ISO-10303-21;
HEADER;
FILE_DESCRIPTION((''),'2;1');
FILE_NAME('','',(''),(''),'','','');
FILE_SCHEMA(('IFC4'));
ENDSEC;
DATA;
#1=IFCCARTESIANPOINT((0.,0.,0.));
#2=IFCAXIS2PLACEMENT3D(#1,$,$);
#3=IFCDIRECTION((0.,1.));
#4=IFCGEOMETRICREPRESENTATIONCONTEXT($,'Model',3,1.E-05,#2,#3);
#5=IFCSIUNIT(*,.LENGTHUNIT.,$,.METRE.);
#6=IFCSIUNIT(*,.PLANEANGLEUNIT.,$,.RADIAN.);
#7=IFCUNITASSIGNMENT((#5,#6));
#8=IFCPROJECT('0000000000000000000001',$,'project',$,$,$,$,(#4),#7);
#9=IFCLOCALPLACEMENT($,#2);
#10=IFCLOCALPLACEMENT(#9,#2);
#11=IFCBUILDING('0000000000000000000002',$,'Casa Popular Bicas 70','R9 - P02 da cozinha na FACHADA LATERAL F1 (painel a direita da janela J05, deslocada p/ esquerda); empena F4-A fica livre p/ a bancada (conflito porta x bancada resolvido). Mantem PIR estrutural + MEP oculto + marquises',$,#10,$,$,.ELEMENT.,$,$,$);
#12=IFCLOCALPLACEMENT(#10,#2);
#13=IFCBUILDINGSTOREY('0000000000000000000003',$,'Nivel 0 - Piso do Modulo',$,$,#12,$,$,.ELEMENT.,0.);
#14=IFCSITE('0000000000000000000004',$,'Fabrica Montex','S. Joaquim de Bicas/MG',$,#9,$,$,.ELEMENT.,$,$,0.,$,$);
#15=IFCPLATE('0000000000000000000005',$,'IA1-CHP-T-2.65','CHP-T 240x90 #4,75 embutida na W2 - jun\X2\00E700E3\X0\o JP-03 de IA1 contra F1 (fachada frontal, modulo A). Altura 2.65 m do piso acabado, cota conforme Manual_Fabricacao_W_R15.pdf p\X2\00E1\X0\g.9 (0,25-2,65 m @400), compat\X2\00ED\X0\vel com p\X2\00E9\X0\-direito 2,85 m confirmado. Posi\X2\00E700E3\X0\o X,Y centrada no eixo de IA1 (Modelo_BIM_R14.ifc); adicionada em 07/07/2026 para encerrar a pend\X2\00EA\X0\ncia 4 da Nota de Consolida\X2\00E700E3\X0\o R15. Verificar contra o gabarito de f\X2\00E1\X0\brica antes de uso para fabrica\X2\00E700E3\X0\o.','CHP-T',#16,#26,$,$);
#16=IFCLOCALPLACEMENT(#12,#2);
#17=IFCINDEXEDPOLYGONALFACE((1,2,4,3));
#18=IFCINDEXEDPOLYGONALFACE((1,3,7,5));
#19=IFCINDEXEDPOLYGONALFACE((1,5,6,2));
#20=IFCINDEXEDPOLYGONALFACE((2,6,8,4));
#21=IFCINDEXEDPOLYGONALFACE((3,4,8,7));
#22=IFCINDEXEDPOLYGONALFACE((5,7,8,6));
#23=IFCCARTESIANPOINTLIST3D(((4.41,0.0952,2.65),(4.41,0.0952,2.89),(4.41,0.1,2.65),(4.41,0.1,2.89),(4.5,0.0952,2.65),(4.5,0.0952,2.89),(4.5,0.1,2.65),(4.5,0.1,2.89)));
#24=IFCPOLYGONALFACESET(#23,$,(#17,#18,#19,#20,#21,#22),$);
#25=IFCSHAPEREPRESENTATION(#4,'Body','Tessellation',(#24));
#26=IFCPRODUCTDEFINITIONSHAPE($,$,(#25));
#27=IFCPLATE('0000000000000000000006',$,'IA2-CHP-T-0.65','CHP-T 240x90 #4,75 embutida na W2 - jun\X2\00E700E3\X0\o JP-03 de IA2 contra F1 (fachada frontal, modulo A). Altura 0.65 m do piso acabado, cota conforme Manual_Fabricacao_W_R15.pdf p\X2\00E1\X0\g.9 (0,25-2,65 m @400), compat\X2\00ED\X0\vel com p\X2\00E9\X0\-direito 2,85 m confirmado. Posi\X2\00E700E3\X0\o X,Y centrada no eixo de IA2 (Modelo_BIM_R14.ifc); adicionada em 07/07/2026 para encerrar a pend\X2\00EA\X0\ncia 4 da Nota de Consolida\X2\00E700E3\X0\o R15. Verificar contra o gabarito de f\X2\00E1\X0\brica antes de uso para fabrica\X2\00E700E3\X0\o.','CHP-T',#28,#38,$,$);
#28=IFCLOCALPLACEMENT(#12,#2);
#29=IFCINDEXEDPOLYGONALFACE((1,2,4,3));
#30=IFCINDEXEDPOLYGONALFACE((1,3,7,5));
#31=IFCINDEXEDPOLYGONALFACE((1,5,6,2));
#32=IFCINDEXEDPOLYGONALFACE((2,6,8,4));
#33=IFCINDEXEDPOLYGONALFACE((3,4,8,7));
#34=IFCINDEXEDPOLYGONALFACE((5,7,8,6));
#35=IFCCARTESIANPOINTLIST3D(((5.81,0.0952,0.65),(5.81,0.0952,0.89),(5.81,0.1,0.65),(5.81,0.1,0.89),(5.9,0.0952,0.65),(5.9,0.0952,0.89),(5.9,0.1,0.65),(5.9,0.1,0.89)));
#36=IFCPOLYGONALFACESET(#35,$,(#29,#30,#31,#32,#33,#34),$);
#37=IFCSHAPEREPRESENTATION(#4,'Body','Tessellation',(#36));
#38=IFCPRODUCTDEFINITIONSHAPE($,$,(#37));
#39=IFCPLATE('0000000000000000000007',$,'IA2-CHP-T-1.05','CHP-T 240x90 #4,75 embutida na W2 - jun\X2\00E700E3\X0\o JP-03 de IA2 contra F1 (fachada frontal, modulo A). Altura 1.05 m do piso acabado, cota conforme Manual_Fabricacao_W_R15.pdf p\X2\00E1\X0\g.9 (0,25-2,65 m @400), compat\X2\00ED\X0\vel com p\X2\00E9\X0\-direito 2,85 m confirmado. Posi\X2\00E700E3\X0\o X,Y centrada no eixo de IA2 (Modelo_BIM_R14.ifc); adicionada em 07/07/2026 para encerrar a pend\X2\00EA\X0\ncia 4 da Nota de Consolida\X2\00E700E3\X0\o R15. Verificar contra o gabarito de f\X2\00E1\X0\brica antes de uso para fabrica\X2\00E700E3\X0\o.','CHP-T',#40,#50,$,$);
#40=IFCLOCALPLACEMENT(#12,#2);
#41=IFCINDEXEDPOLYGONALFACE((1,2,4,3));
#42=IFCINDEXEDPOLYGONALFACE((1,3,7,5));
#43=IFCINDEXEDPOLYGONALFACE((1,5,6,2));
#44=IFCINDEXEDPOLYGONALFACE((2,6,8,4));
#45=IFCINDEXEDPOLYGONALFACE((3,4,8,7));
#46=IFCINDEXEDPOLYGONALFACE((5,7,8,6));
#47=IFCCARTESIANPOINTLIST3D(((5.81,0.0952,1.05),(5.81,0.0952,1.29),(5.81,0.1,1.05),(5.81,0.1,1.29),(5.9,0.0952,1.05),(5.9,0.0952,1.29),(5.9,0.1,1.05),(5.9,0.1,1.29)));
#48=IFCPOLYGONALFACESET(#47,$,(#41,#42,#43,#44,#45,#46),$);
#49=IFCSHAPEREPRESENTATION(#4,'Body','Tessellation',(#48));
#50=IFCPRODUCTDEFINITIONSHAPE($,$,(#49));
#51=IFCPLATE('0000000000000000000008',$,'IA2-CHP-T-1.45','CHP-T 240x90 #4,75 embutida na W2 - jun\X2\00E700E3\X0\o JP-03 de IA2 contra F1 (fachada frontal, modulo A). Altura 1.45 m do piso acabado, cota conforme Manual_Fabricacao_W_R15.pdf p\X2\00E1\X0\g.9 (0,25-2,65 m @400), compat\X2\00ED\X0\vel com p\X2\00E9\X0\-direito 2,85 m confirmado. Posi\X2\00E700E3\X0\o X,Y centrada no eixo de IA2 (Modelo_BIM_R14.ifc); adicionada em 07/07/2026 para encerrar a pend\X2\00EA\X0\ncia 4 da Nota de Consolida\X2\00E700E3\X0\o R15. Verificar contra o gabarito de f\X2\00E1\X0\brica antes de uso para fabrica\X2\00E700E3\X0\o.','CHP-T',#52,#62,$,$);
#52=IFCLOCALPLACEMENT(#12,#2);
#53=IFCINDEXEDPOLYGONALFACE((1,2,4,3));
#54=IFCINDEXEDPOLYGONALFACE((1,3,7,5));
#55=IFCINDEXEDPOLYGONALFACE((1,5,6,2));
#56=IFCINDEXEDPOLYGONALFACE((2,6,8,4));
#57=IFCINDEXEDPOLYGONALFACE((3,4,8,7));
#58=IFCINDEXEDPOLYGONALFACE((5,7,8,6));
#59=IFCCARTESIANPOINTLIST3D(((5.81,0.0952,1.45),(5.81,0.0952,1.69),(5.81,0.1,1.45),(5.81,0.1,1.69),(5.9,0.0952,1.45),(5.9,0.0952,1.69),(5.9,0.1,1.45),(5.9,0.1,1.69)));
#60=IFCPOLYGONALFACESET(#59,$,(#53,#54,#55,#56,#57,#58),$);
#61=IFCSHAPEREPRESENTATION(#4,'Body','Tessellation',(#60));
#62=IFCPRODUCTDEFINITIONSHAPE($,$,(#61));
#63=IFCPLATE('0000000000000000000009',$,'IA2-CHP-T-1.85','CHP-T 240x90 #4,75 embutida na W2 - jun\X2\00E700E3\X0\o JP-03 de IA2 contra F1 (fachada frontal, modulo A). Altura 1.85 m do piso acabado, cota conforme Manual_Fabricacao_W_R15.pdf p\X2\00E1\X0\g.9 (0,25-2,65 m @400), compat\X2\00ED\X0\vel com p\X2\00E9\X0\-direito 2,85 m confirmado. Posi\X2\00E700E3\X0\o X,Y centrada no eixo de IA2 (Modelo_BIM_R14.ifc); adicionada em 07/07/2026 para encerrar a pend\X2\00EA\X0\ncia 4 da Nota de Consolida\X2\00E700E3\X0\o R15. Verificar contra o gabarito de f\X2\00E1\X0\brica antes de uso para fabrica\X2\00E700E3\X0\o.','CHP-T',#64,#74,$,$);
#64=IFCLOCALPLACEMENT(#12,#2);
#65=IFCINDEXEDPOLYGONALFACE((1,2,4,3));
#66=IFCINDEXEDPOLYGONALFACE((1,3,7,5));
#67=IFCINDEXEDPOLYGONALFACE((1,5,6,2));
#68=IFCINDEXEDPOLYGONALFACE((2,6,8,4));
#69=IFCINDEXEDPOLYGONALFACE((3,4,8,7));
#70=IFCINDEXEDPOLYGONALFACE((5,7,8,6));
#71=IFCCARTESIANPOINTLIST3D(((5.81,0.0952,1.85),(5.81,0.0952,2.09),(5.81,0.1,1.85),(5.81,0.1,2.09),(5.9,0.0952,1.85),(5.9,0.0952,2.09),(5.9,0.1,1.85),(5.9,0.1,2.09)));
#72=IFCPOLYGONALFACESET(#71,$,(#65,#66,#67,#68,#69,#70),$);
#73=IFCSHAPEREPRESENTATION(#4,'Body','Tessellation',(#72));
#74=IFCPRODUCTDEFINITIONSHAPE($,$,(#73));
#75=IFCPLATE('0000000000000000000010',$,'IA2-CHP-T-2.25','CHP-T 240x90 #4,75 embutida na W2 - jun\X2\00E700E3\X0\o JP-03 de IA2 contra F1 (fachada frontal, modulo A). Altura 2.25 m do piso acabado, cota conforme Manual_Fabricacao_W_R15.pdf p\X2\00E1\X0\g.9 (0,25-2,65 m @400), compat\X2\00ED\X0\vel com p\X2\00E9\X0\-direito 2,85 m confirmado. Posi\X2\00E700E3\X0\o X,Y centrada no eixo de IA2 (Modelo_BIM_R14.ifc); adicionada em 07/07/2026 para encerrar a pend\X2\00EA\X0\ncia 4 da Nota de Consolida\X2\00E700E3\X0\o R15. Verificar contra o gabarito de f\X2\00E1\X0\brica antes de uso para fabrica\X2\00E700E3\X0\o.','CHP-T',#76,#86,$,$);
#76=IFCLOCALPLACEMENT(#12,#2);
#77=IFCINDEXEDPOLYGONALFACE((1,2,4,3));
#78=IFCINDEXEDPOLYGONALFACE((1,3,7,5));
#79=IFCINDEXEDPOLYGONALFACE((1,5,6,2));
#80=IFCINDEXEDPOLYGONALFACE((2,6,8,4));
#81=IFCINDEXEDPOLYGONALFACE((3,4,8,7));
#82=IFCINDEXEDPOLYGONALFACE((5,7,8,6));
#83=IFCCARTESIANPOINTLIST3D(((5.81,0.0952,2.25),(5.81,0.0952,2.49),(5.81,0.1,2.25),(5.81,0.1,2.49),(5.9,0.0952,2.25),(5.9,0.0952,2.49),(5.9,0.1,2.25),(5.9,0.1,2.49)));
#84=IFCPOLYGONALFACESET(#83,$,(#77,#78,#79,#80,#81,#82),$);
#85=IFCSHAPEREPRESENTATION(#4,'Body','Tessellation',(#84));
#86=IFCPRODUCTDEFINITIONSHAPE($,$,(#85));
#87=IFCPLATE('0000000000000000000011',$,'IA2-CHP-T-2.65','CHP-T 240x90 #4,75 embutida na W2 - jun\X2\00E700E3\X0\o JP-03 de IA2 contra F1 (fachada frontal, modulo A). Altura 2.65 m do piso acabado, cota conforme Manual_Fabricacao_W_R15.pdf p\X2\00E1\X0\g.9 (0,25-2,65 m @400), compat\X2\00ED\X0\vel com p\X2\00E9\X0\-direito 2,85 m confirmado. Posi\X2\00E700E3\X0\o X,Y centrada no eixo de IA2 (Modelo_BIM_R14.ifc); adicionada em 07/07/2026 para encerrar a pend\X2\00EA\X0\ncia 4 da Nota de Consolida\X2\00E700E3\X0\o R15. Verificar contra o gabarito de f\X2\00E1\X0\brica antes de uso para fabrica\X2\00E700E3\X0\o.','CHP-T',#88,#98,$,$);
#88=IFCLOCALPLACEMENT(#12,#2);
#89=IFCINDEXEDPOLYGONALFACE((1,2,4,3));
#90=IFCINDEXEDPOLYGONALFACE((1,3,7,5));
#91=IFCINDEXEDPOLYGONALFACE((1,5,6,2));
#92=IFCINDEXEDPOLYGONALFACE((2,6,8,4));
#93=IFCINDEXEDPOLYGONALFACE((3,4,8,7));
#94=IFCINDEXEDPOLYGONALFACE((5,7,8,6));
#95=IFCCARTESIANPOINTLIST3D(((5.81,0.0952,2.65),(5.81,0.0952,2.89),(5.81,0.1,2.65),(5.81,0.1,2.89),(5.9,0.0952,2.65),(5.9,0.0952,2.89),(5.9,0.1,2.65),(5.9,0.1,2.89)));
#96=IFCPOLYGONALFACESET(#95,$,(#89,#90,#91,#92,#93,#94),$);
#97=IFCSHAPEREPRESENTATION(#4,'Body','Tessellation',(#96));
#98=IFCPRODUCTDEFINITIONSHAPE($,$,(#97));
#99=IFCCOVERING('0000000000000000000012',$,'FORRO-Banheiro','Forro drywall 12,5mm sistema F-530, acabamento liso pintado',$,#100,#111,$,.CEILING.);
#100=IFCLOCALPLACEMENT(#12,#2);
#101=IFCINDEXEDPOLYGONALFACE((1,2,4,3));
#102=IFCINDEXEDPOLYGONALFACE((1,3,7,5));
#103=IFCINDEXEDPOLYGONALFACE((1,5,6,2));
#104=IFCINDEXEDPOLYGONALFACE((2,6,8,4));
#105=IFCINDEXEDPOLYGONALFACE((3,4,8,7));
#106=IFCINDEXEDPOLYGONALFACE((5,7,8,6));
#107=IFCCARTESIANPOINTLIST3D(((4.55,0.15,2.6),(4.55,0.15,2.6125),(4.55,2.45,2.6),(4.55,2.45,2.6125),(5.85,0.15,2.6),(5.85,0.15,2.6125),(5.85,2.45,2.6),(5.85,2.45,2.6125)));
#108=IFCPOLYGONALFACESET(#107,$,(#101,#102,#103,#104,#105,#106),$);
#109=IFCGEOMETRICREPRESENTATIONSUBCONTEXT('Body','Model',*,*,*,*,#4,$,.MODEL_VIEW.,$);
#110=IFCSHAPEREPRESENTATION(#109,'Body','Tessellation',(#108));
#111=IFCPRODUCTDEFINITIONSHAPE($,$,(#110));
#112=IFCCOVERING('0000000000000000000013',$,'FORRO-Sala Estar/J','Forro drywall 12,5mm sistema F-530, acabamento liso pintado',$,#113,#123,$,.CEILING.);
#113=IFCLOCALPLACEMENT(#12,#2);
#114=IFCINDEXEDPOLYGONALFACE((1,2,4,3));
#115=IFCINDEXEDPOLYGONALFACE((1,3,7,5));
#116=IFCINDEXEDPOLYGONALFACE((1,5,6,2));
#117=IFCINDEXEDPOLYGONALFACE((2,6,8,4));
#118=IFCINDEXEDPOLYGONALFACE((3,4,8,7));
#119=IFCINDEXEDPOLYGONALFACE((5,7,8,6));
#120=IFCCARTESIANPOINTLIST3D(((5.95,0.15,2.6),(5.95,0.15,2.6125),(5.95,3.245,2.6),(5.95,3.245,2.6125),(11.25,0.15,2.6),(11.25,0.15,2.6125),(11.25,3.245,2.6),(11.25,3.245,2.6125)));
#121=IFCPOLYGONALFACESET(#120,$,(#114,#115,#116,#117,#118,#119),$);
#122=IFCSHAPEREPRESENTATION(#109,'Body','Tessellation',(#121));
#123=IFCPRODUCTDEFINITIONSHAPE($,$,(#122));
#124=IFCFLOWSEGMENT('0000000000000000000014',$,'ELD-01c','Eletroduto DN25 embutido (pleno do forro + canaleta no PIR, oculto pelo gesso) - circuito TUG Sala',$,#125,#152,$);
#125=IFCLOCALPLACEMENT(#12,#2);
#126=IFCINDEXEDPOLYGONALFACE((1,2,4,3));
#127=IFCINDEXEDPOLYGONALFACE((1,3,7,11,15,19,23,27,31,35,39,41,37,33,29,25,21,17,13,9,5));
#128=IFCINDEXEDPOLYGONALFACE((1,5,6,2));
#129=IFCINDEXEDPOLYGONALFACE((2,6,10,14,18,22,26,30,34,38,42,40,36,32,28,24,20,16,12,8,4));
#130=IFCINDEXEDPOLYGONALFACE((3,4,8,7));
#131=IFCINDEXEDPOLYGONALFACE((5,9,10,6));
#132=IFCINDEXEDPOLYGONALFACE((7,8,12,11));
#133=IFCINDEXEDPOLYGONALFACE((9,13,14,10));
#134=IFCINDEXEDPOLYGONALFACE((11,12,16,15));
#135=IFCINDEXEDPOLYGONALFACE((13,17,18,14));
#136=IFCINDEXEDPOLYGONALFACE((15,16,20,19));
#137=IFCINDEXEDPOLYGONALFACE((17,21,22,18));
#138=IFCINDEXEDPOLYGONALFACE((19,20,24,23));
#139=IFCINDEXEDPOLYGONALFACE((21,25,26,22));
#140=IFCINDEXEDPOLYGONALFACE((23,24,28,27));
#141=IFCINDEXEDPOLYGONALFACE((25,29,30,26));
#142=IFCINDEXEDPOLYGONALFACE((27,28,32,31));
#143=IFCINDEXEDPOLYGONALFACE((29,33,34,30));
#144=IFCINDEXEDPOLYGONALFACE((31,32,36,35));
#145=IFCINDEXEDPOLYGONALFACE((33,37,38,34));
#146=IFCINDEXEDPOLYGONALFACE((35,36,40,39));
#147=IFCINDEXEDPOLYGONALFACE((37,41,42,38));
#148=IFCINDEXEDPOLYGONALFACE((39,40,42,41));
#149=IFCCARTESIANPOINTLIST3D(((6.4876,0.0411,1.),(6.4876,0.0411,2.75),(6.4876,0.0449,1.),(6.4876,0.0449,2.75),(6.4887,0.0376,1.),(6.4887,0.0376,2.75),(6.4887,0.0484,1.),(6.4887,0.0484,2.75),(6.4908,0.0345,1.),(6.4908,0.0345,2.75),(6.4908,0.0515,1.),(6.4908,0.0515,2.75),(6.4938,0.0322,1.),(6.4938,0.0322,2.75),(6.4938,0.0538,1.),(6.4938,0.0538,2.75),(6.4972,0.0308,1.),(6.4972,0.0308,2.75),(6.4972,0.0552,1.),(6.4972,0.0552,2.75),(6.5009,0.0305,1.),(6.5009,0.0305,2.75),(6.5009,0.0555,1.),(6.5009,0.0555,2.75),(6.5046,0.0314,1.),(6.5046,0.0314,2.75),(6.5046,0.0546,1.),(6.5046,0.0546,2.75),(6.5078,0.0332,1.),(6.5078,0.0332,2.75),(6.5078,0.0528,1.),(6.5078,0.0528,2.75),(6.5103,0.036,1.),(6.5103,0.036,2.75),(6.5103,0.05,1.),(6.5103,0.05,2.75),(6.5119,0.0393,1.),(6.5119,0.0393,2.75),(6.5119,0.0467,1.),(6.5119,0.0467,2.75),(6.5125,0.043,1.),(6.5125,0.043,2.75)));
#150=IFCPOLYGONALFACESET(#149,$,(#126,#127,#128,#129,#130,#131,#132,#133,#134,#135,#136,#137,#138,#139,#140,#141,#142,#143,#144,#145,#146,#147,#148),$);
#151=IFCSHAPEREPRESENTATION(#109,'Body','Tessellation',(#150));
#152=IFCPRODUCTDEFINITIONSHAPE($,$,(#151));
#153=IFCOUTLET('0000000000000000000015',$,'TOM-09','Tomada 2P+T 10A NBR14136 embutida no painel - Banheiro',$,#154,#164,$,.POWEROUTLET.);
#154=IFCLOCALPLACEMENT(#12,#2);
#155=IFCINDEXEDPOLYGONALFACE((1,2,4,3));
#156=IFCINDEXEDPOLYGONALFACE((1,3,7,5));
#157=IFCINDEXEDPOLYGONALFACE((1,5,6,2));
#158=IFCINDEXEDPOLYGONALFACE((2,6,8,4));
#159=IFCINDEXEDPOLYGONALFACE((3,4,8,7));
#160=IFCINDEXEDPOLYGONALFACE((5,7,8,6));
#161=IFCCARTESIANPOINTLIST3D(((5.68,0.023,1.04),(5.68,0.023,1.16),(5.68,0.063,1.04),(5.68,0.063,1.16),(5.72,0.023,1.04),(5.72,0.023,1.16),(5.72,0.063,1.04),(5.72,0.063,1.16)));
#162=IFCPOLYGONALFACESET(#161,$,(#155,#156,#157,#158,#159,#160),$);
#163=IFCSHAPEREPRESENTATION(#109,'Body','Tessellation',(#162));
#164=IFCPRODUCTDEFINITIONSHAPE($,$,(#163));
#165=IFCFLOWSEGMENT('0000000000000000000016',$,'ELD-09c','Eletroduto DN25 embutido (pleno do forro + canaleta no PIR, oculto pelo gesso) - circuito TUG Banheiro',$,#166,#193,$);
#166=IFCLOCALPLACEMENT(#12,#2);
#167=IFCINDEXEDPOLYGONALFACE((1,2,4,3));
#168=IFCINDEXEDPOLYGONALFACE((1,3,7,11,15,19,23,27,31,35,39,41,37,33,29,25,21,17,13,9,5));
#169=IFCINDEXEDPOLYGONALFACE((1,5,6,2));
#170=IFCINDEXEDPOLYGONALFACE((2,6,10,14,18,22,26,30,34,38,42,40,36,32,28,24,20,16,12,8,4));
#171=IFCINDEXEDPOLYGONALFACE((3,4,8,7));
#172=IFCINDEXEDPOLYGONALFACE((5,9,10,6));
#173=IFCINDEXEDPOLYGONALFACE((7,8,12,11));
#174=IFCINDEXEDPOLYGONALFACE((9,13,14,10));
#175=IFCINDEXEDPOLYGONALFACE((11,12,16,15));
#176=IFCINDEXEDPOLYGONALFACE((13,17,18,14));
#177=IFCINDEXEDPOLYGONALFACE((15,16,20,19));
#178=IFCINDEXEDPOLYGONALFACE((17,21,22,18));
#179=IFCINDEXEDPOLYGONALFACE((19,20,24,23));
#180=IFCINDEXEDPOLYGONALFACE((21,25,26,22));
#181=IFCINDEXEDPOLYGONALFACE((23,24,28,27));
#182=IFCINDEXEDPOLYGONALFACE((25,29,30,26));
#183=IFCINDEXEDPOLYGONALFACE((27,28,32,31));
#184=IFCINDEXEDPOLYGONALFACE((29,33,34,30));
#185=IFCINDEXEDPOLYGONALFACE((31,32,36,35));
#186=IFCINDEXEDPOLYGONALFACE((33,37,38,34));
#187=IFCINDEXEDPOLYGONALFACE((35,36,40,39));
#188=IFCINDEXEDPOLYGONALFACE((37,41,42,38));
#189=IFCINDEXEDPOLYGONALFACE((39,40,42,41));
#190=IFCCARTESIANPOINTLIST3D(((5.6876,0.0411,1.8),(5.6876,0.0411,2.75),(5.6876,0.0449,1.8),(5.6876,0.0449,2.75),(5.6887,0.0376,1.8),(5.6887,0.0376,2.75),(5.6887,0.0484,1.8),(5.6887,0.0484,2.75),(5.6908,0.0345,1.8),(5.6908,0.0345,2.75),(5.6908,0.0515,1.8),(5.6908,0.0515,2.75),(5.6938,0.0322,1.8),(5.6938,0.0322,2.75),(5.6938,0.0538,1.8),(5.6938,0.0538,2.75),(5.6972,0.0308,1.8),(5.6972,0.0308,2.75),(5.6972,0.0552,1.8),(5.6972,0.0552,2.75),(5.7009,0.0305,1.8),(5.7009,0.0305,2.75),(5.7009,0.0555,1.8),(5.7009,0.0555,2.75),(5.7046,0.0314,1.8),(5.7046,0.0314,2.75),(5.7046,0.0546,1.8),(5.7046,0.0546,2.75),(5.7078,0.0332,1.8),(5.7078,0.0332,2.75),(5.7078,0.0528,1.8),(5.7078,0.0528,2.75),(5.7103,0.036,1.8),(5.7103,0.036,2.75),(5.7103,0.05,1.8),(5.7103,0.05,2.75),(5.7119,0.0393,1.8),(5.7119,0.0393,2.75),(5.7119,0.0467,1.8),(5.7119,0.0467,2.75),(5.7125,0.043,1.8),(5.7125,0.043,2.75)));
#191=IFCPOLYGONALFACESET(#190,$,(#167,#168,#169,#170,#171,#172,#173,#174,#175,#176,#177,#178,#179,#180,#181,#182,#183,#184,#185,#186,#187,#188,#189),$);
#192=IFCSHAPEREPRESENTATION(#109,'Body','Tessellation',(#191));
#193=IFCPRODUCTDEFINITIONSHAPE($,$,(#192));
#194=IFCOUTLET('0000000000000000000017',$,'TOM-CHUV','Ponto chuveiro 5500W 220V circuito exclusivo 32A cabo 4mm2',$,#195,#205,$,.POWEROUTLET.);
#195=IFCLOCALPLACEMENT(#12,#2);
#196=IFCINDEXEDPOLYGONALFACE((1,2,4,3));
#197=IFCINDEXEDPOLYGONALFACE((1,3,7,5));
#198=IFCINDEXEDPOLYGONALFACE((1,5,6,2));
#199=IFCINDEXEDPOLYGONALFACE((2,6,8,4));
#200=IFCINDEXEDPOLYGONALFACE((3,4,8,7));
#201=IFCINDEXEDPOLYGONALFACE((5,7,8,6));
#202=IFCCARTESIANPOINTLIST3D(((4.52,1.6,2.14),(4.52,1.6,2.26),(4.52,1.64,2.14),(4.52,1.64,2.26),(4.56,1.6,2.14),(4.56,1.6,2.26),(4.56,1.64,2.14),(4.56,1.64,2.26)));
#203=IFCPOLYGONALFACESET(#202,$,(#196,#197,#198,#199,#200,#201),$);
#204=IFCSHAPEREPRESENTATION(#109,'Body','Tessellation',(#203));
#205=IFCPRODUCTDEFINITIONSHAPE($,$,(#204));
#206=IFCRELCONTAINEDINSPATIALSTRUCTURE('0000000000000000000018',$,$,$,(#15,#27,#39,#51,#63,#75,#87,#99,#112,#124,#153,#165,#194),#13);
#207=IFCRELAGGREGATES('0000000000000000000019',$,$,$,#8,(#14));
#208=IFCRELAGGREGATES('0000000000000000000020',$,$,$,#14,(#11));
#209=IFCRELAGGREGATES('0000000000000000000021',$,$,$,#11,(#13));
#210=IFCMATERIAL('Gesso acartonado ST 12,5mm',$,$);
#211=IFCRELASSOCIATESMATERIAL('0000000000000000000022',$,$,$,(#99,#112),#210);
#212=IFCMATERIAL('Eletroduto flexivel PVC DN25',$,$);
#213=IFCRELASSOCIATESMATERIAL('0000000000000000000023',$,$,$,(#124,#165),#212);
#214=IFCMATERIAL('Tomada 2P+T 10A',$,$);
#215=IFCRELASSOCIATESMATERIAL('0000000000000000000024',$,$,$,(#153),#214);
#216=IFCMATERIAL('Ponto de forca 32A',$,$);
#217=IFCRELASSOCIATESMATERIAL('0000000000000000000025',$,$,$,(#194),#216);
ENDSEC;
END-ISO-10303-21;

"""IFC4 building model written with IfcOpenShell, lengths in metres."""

from ifc_helpers import new_model, si_unit, direction, frame, frame_2d, origin, origin_with_axes, origin_2d, place, context, subcontext, project, spatial, rectangle, circle, extrude, material, element, save


model = new_model("IFC4")

# Units and contexts
model_context = context("Model", 3, precision=1e-05, world=origin(), true_north=direction((0.0, 1.0)))
body_context = subcontext(model_context, "Body", "Model", "MODEL_VIEW")
ifc_project = project(units=[si_unit("LENGTHUNIT", "METRE"), si_unit("PLANEANGLEUNIT", "RADIAN")], contexts=[model_context])

# Site, building, storey
site_placement = place(None, origin())
site = spatial("IfcSite", under=ifc_project, at=site_placement, Name="Fabrica Montex", Description="S. Joaquim de Bicas/MG", CompositionType="ELEMENT", RefElevation=0.0)
building_placement = place(site_placement, origin())
building = spatial("IfcBuilding", under=site, at=building_placement, Name="Casa Popular Bicas 70", Description="R9 - P02 da cozinha na FACHADA LATERAL F1 (painel a direita da janela J05, deslocada p/ esquerda); empena F4-A fica livre p/ a bancada (conflito porta x bancada resolvido). Mantem PIR estrutural + MEP oculto + marquises", CompositionType="ELEMENT")
storey_placement = place(building_placement, origin())
storey = spatial("IfcBuildingStorey", under=building, at=storey_placement, Name="Nivel 0 - Piso do Modulo", CompositionType="ELEMENT", Elevation=0.0)

# Plates
for number, where, z_axis, x_axis, name, description in (
    (1, (4.455, 0.0976, 2.65), (0.0, 0.0, 1.0), (1.0, 0.0, 0.0), "IA1-CHP-T-2.65", "CHP-T 240x90 #4,75 embutida na W2 - junção JP-03 de IA1 contra F1 (fachada frontal, modulo A). Altura 2.65 m do piso acabado, cota conforme Manual_Fabricacao_W_R15.pdf pág.9 (0,25-2,65 m @400), compatível com pé-direito 2,85 m confirmado. Posição X,Y centrada no eixo de IA1 (Modelo_BIM_R14.ifc); adicionada em 07/07/2026 para encerrar a pendência 4 da Nota de Consolidação R15. Verificar contra o gabarito de fábrica antes de uso para fabricação."),
    (2, (5.855, 0.0976, 0.65), (0.0, 0.0, 1.0), (1.0, 0.0, 0.0), "IA2-CHP-T-0.65", "CHP-T 240x90 #4,75 embutida na W2 - junção JP-03 de IA2 contra F1 (fachada frontal, modulo A). Altura 0.65 m do piso acabado, cota conforme Manual_Fabricacao_W_R15.pdf pág.9 (0,25-2,65 m @400), compatível com pé-direito 2,85 m confirmado. Posição X,Y centrada no eixo de IA2 (Modelo_BIM_R14.ifc); adicionada em 07/07/2026 para encerrar a pendência 4 da Nota de Consolidação R15. Verificar contra o gabarito de fábrica antes de uso para fabricação."),
    (3, (5.855, 0.0976, 1.05), (0.0, 0.0, 1.0), (1.0, 0.0, 0.0), "IA2-CHP-T-1.05", "CHP-T 240x90 #4,75 embutida na W2 - junção JP-03 de IA2 contra F1 (fachada frontal, modulo A). Altura 1.05 m do piso acabado, cota conforme Manual_Fabricacao_W_R15.pdf pág.9 (0,25-2,65 m @400), compatível com pé-direito 2,85 m confirmado. Posição X,Y centrada no eixo de IA2 (Modelo_BIM_R14.ifc); adicionada em 07/07/2026 para encerrar a pendência 4 da Nota de Consolidação R15. Verificar contra o gabarito de fábrica antes de uso para fabricação."),
    (4, (5.855, 0.0976, 1.45), (0.0, 0.0, 1.0), (1.0, 0.0, 0.0), "IA2-CHP-T-1.45", "CHP-T 240x90 #4,75 embutida na W2 - junção JP-03 de IA2 contra F1 (fachada frontal, modulo A). Altura 1.45 m do piso acabado, cota conforme Manual_Fabricacao_W_R15.pdf pág.9 (0,25-2,65 m @400), compatível com pé-direito 2,85 m confirmado. Posição X,Y centrada no eixo de IA2 (Modelo_BIM_R14.ifc); adicionada em 07/07/2026 para encerrar a pendência 4 da Nota de Consolidação R15. Verificar contra o gabarito de fábrica antes de uso para fabricação."),
    (5, (5.855, 0.0976, 1.85), (0.0, 0.0, 1.0), (1.0, 0.0, 0.0), "IA2-CHP-T-1.85", "CHP-T 240x90 #4,75 embutida na W2 - junção JP-03 de IA2 contra F1 (fachada frontal, modulo A). Altura 1.85 m do piso acabado, cota conforme Manual_Fabricacao_W_R15.pdf pág.9 (0,25-2,65 m @400), compatível com pé-direito 2,85 m confirmado. Posição X,Y centrada no eixo de IA2 (Modelo_BIM_R14.ifc); adicionada em 07/07/2026 para encerrar a pendência 4 da Nota de Consolidação R15. Verificar contra o gabarito de fábrica antes de uso para fabricação."),
    (6, (5.855, 0.0976, 2.25), (0.0, 0.0, 1.0), (1.0, 0.0, 0.0), "IA2-CHP-T-2.25", "CHP-T 240x90 #4,75 embutida na W2 - junção JP-03 de IA2 contra F1 (fachada frontal, modulo A). Altura 2.25 m do piso acabado, cota conforme Manual_Fabricacao_W_R15.pdf pág.9 (0,25-2,65 m @400), compatível com pé-direito 2,85 m confirmado. Posição X,Y centrada no eixo de IA2 (Modelo_BIM_R14.ifc); adicionada em 07/07/2026 para encerrar a pendência 4 da Nota de Consolidação R15. Verificar contra o gabarito de fábrica antes de uso para fabricação."),
    (7, (5.855, 0.0976, 2.65), (0.0, 0.0, 1.0), (1.0, 0.0, 0.0), "IA2-CHP-T-2.65", "CHP-T 240x90 #4,75 embutida na W2 - junção JP-03 de IA2 contra F1 (fachada frontal, modulo A). Altura 2.65 m do piso acabado, cota conforme Manual_Fabricacao_W_R15.pdf pág.9 (0,25-2,65 m @400), compatível com pé-direito 2,85 m confirmado. Posição X,Y centrada no eixo de IA2 (Modelo_BIM_R14.ifc); adicionada em 07/07/2026 para encerrar a pendência 4 da Nota de Consolidação R15. Verificar contra o gabarito de fábrica antes de uso para fabricação."),
):
    element("IfcPlate", number, at=place(storey_placement, frame(where, z_axis=z_axis, x_axis=x_axis)), inside=storey, Name=name, Description=description, ObjectType="CHP-T", context=model_context, shape_type="SweptSolid", body=[
        extrude(rectangle(XDim=0.09, YDim=0.0047, at=origin_2d()), origin_with_axes(), (0.0, 0.0, 1.0), 0.24),
    ])

# Coverings
ifc_material_1 = material(Name="Gesso acartonado ST 12,5mm")
covering_1_placement = place(storey_placement, frame((4.55, 0.15, 2.6)))
element("IfcCovering", 8, at=covering_1_placement, inside=storey, material=ifc_material_1, Name="FORRO-Banheiro", Description="Forro drywall 12,5mm sistema F-530, acabamento liso pintado", PredefinedType="CEILING", context=body_context, shape_type="SweptSolid", body=[
    extrude(rectangle(XDim=1.3, YDim=2.3, at=frame_2d((0.65, 1.15))), origin(), (0.0, 0.0, 1.0), 0.0125),
])
covering_2_placement = place(storey_placement, frame((5.95, 0.15, 2.6)))
element("IfcCovering", 9, at=covering_2_placement, inside=storey, material=ifc_material_1, Name="FORRO-Sala Estar/J", Description="Forro drywall 12,5mm sistema F-530, acabamento liso pintado", PredefinedType="CEILING", context=body_context, shape_type="SweptSolid", body=[
    extrude(rectangle(XDim=5.3, YDim=3.095, at=frame_2d((2.65, 1.5475))), origin(), (0.0, 0.0, 1.0), 0.0125),
])

# Flow segment
ifc_material_2 = material(Name="Eletroduto flexivel PVC DN25")
flow_segment_1_placement = place(storey_placement, frame((6.5, 0.043, 2.75), z_axis=(0.0, 0.0, -1.0), x_axis=(1.0, 0.0, 0.0)))
element("IfcFlowSegment", 10, at=flow_segment_1_placement, inside=storey, material=ifc_material_2, Name="ELD-01c", Description="Eletroduto DN25 embutido (pleno do forro + canaleta no PIR, oculto pelo gesso) - circuito TUG Sala", context=body_context, shape_type="SweptSolid", body=[
    extrude(circle(Radius=0.0125, at=origin_2d()), origin(), (0.0, 0.0, 1.0), 1.75),
])

# Outlet
ifc_material_3 = material(Name="Tomada 2P+T 10A")
outlet_1_placement = place(storey_placement, frame((5.68, 0.023, 1.04)))
element("IfcOutlet", 11, at=outlet_1_placement, inside=storey, material=ifc_material_3, Name="TOM-09", Description="Tomada 2P+T 10A NBR14136 embutida no painel - Banheiro", PredefinedType="POWEROUTLET", context=body_context, shape_type="SweptSolid", body=[
    extrude(rectangle(XDim=0.04, YDim=0.04, at=frame_2d((0.02, 0.02))), origin(), (0.0, 0.0, 1.0), 0.12),
])

# Flow segment
flow_segment_2_placement = place(storey_placement, frame((5.7, 0.043, 2.75), z_axis=(0.0, 0.0, -1.0), x_axis=(1.0, 0.0, 0.0)))
element("IfcFlowSegment", 12, at=flow_segment_2_placement, inside=storey, material=ifc_material_2, Name="ELD-09c", Description="Eletroduto DN25 embutido (pleno do forro + canaleta no PIR, oculto pelo gesso) - circuito TUG Banheiro", context=body_context, shape_type="SweptSolid", body=[
    extrude(circle(Radius=0.0125, at=origin_2d()), origin(), (0.0, 0.0, 1.0), 0.95),
])

# Outlet
ifc_material_4 = material(Name="Ponto de forca 32A")
outlet_2_placement = place(storey_placement, frame((4.52, 1.6, 2.14)))
element("IfcOutlet", 13, at=outlet_2_placement, inside=storey, material=ifc_material_4, Name="TOM-CHUV", Description="Ponto chuveiro 5500W 220V circuito exclusivo 32A cabo 4mm2", PredefinedType="POWEROUTLET", context=body_context, shape_type="SweptSolid", body=[
    extrude(rectangle(XDim=0.04, YDim=0.04, at=frame_2d((0.02, 0.02))), origin(), (0.0, 0.0, 1.0), 0.12),
])

save(model, "model.ifc")
